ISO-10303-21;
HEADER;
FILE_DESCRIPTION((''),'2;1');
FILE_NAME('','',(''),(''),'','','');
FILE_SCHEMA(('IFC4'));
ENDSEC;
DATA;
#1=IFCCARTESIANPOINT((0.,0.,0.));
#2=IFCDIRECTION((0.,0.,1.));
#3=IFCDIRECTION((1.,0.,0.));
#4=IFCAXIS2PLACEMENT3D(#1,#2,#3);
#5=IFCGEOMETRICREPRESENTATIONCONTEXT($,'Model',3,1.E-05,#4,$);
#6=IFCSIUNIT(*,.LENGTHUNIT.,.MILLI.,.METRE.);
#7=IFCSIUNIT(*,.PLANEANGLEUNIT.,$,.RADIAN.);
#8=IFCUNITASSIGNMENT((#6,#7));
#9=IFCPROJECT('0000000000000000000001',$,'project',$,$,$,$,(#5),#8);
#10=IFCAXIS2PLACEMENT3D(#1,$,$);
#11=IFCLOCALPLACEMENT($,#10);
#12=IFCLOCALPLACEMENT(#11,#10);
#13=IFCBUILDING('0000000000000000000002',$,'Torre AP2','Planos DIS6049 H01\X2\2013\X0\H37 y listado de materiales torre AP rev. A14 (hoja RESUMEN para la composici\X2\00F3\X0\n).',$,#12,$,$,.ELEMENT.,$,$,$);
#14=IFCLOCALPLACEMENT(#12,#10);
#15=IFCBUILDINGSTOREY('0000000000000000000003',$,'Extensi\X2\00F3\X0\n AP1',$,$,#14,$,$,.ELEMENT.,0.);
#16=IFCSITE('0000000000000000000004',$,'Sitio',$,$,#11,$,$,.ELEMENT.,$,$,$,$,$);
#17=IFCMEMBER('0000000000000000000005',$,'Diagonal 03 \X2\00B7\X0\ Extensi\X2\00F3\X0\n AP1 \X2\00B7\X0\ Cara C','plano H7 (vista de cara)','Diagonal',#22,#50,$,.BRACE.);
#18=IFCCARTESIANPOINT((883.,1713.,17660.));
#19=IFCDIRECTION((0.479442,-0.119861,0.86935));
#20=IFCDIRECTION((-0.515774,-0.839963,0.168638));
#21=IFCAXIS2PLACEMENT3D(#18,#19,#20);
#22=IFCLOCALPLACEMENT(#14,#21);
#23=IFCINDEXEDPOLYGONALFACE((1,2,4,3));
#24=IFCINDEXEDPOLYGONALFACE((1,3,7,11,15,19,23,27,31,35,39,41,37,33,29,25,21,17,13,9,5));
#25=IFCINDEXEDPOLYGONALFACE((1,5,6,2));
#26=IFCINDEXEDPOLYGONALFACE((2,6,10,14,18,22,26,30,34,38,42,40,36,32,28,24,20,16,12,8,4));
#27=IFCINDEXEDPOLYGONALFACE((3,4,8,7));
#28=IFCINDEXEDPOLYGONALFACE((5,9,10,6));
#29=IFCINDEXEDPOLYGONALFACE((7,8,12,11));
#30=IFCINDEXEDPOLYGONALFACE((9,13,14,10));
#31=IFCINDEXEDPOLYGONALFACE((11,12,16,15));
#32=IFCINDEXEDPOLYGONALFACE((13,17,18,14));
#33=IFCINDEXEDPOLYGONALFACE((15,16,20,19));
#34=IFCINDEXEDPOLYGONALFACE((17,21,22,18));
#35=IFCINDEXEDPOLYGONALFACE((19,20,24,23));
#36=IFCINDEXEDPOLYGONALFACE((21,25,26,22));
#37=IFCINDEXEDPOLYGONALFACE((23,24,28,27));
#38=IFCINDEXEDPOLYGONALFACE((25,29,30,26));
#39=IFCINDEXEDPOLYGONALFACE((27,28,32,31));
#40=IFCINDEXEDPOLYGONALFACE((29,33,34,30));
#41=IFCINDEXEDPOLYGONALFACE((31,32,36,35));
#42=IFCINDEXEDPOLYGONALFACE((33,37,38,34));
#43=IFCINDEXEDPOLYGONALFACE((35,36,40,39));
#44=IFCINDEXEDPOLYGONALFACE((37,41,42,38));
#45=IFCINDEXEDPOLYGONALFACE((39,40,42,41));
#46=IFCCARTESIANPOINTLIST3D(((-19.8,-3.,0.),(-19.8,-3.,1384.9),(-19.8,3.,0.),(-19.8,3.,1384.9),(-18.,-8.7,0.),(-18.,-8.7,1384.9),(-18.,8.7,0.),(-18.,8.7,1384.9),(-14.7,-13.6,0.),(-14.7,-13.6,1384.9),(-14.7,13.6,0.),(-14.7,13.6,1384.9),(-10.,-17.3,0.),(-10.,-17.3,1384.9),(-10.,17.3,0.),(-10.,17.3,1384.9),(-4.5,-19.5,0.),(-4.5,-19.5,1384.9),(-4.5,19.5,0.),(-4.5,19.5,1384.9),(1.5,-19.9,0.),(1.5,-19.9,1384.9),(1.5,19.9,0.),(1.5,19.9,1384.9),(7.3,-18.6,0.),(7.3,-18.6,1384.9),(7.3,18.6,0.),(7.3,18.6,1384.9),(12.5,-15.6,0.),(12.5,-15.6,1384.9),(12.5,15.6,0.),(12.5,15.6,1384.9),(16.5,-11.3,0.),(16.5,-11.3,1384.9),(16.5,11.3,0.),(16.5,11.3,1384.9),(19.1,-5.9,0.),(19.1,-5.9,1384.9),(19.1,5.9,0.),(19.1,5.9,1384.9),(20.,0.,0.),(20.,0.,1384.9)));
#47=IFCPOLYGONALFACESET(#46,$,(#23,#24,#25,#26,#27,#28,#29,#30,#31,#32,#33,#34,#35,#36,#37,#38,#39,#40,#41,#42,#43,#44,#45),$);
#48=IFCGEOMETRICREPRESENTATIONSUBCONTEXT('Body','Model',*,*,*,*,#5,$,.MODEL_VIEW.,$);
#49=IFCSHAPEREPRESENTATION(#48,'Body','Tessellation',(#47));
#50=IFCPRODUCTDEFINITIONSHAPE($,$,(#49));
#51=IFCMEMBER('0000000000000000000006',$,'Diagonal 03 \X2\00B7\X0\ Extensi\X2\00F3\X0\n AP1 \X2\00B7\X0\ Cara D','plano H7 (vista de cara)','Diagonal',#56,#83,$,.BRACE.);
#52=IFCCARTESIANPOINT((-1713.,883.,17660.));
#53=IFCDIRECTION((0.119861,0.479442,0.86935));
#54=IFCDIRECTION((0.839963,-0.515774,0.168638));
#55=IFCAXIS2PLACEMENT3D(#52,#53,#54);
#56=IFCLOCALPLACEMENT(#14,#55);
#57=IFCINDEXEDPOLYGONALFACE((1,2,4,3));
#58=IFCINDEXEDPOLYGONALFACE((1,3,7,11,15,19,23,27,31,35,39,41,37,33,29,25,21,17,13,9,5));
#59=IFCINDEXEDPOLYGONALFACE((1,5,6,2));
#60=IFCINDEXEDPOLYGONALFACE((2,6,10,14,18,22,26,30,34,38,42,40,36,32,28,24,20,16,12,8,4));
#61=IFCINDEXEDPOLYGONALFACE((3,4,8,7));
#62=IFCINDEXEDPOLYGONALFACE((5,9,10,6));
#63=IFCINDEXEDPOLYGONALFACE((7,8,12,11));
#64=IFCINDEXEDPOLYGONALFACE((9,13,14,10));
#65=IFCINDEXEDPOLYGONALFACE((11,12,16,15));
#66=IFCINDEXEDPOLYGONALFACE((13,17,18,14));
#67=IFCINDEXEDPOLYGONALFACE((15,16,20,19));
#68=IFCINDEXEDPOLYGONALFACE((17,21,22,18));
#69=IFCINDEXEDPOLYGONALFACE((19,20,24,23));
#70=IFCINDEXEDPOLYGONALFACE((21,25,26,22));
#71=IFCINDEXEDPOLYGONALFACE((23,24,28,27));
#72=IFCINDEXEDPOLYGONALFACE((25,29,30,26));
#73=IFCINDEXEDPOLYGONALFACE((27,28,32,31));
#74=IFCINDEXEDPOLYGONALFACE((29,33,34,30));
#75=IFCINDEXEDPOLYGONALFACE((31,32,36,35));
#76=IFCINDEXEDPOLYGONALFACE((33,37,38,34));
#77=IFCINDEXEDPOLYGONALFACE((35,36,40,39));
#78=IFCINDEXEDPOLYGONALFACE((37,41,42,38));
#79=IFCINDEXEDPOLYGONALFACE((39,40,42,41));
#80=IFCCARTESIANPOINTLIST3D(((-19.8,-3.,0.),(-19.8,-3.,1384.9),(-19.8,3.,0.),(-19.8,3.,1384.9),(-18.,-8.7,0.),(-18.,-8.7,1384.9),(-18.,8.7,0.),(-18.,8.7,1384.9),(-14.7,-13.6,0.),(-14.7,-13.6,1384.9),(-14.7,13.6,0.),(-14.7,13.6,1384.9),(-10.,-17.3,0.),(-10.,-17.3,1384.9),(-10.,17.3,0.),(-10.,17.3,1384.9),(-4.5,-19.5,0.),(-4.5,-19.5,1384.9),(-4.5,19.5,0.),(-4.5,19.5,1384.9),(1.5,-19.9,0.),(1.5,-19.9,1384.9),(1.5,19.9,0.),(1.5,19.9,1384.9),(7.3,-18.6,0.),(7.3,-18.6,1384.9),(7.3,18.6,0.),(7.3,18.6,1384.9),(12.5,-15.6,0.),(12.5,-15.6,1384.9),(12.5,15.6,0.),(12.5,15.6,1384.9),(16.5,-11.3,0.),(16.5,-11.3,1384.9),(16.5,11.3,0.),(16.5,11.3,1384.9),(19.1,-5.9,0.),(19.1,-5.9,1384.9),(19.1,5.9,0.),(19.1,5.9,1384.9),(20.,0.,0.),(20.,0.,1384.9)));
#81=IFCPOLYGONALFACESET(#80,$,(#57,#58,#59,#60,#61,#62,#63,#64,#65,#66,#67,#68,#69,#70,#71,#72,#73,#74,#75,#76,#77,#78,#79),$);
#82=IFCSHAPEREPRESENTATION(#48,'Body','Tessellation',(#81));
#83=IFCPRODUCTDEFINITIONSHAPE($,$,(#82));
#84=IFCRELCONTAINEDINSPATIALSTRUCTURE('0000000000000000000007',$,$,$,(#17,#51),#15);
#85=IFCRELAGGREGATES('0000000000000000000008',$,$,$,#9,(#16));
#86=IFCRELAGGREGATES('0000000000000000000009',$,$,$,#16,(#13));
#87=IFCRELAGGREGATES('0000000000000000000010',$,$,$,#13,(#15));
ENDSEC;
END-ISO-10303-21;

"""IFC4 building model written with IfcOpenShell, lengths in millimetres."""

from ifc_helpers import new_model, si_unit, frame, origin, origin_with_axes, place, context, subcontext, project, spatial, circle, extrude, element, save


model = new_model("IFC4")

# Units and contexts
model_context = context("Model", 3, precision=1e-05, world=origin_with_axes())
body_context = subcontext(model_context, "Body", "Model", "MODEL_VIEW")
ifc_project = project(units=[si_unit("LENGTHUNIT", "METRE", prefix="MILLI"), si_unit("PLANEANGLEUNIT", "RADIAN")], contexts=[model_context])

# Site, building, storey
site_placement = place(None, origin())
site = spatial("IfcSite", under=ifc_project, at=site_placement, Name="Sitio", CompositionType="ELEMENT")
building_placement = place(site_placement, origin())
building = spatial("IfcBuilding", under=site, at=building_placement, Name="Torre AP2", Description="Planos DIS6049 H01–H37 y listado de materiales torre AP rev. A14 (hoja RESUMEN para la composición).", CompositionType="ELEMENT")
storey_placement = place(building_placement, origin())
storey = spatial("IfcBuildingStorey", under=building, at=storey_placement, Name="Extensión AP1", CompositionType="ELEMENT", Elevation=0.0)

# Members
for number, where, z_axis, x_axis, name in (
    (1, (883.0, 1713.0, 17660.0), (0.479442, -0.119861, 0.86935), (-0.515774, -0.839963, 0.168638), "Diagonal 03 · Extensión AP1 · Cara C"),
    (2, (-1713.0, 883.0, 17660.0), (0.119861, 0.479442, 0.86935), (0.839963, -0.515774, 0.168638), "Diagonal 03 · Extensión AP1 · Cara D"),
):
    element("IfcMember", number, at=place(storey_placement, frame(where, z_axis=z_axis, x_axis=x_axis)), inside=storey, Name=name, Description="plano H7 (vista de cara)", ObjectType="Diagonal", PredefinedType="BRACE", context=body_context, shape_type="SweptSolid", body=[
        extrude(circle(Radius=20.0), None, (0.0, 0.0, 1.0), 1384.9),
    ])

save(model, "model.ifc")
